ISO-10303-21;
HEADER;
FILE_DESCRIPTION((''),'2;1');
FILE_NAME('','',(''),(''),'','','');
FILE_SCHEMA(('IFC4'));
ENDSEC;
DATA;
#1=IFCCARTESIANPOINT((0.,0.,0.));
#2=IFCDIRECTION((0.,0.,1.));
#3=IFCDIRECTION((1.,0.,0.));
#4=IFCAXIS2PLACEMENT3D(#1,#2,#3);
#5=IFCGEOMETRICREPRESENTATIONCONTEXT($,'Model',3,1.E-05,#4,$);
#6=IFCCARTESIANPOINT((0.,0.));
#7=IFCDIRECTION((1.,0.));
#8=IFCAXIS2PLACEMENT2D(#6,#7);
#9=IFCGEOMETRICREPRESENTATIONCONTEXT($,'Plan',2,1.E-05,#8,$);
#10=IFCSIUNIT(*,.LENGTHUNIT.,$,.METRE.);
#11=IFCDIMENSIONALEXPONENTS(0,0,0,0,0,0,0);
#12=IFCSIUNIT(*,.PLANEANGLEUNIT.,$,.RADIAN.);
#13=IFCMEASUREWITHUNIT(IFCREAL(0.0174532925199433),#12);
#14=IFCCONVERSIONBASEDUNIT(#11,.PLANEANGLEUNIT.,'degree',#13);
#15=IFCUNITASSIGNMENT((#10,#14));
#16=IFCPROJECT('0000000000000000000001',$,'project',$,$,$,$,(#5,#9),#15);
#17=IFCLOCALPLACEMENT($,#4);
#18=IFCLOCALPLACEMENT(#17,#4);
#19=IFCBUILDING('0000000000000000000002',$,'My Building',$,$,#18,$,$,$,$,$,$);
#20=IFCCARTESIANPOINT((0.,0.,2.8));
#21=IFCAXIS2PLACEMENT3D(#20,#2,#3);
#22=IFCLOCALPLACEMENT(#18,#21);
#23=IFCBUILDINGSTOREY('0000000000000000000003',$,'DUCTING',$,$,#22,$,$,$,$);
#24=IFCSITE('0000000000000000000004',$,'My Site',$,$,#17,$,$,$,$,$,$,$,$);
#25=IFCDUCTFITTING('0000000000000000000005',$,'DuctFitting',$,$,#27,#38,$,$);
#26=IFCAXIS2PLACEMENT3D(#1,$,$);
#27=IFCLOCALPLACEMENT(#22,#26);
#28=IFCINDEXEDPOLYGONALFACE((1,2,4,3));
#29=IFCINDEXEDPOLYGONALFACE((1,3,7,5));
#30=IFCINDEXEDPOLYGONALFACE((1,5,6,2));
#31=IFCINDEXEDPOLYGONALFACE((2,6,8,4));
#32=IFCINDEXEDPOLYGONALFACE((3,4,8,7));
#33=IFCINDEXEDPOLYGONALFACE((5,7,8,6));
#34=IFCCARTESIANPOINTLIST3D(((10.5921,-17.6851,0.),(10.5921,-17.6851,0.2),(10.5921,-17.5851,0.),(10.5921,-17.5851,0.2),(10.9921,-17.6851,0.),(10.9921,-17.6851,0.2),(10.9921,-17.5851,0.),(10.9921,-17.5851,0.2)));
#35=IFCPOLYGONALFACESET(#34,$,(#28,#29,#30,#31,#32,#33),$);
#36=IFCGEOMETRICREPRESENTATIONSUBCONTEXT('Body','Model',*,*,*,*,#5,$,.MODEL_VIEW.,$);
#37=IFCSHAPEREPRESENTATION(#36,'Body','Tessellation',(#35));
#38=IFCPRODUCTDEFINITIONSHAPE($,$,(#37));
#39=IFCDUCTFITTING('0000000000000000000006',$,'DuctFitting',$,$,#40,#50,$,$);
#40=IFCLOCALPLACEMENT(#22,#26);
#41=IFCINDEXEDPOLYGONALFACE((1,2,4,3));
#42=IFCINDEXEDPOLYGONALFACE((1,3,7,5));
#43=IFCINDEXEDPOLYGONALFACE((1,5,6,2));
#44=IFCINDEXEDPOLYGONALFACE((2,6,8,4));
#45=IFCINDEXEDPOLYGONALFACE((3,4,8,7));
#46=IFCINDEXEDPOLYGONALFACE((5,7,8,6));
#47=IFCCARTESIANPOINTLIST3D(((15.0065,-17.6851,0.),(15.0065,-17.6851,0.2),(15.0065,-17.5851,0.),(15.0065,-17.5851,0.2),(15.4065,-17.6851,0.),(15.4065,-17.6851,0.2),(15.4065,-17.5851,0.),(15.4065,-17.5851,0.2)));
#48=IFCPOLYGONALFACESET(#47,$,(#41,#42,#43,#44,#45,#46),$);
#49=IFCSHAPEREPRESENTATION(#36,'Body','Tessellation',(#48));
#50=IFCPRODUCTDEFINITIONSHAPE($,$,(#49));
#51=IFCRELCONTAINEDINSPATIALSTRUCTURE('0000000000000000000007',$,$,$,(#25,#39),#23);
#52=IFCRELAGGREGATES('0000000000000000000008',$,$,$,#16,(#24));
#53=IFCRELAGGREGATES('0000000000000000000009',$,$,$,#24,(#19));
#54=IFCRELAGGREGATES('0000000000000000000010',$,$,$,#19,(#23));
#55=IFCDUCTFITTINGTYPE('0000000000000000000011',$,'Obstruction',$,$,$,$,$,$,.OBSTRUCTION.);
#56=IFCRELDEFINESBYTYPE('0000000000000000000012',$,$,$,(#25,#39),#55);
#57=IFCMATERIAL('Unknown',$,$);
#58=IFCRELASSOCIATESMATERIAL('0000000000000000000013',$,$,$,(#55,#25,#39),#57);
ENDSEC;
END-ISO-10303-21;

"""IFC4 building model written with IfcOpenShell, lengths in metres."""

from ifc_helpers import new_model, entity, si_unit, converted_unit, frame, origin_with_axes, origin_2d_with_axis, place, context, subcontext, project, spatial, rectangle, extrude, material, material_profile, profile_set, profile_usage, type_object, element, save


model = new_model("IFC4")

# Units and contexts
model_context = context("Model", 3, precision=1e-05, world=origin_with_axes())
plan_context = context("Plan", 2, precision=1e-05, world=origin_2d_with_axis())
body_context = subcontext(model_context, "Body", "Model", "MODEL_VIEW")
ifc_project = project(units=[si_unit("LENGTHUNIT", "METRE"), converted_unit("PLANEANGLEUNIT", "degree", entity("IfcReal", 0.0174532925199433), si_unit("PLANEANGLEUNIT", "RADIAN"), dimensions=[0, 0, 0, 0, 0, 0, 0])], contexts=[model_context, plan_context])

# Site, building, storey
site_placement = place(None, origin_with_axes())
site = spatial("IfcSite", under=ifc_project, at=site_placement, Name="My Site")
building_placement = place(site_placement, origin_with_axes())
building = spatial("IfcBuilding", under=site, at=building_placement, Name="My Building")
storey_placement = place(building_placement, frame((0.0, 0.0, 2.8), z_axis=(0.0, 0.0, 1.0), x_axis=(1.0, 0.0, 0.0)))
storey = spatial("IfcBuildingStorey", under=building, at=storey_placement, Name="DUCTING")

# Shared definitions
ifc_material = material(Name="Unknown")

# Duct fittings
ifc_material_profile_1 = material_profile(ifc_material, rectangle(XDim=0.4, YDim=0.2))
ifc_profile_set_1 = profile_set([ifc_material_profile_1])
duct_fitting_type_1 = type_object("IfcDuctFittingType", Name="Obstruction", PredefinedType="OBSTRUCTION", material=ifc_profile_set_1)
ifc_profile_usage_1 = profile_usage(ifc_profile_set_1, cardinal=5)
duct_fitting_1_placement = place(storey_placement, frame((10.7921, -17.6851, 0.1), z_axis=(0.0, 1.0, 0.0), x_axis=(-1.0, 0.0, 0.0)))
element("IfcDuctFitting", 1, at=duct_fitting_1_placement, inside=storey, type_object=duct_fitting_type_1, material=ifc_profile_usage_1, Name="DuctFitting", context=body_context, shape_type="SweptSolid", body=[
    extrude(rectangle(XDim=0.4, YDim=0.2), origin_with_axes(), (0.0, 0.0, 1.0), 0.1),
])
ifc_profile_usage_2 = profile_usage(ifc_profile_set_1, cardinal=5)
duct_fitting_2_placement = place(storey_placement, frame((15.2065, -17.6851, 0.1), z_axis=(0.0, 1.0, 0.0), x_axis=(-1.0, 0.0, 0.0)))
element("IfcDuctFitting", 2, at=duct_fitting_2_placement, inside=storey, type_object=duct_fitting_type_1, material=ifc_profile_usage_2, Name="DuctFitting", context=body_context, shape_type="SweptSolid", body=[
    extrude(rectangle(XDim=0.4, YDim=0.2), origin_with_axes(), (0.0, 0.0, 1.0), 0.1),
])

save(model, "model.ifc")
